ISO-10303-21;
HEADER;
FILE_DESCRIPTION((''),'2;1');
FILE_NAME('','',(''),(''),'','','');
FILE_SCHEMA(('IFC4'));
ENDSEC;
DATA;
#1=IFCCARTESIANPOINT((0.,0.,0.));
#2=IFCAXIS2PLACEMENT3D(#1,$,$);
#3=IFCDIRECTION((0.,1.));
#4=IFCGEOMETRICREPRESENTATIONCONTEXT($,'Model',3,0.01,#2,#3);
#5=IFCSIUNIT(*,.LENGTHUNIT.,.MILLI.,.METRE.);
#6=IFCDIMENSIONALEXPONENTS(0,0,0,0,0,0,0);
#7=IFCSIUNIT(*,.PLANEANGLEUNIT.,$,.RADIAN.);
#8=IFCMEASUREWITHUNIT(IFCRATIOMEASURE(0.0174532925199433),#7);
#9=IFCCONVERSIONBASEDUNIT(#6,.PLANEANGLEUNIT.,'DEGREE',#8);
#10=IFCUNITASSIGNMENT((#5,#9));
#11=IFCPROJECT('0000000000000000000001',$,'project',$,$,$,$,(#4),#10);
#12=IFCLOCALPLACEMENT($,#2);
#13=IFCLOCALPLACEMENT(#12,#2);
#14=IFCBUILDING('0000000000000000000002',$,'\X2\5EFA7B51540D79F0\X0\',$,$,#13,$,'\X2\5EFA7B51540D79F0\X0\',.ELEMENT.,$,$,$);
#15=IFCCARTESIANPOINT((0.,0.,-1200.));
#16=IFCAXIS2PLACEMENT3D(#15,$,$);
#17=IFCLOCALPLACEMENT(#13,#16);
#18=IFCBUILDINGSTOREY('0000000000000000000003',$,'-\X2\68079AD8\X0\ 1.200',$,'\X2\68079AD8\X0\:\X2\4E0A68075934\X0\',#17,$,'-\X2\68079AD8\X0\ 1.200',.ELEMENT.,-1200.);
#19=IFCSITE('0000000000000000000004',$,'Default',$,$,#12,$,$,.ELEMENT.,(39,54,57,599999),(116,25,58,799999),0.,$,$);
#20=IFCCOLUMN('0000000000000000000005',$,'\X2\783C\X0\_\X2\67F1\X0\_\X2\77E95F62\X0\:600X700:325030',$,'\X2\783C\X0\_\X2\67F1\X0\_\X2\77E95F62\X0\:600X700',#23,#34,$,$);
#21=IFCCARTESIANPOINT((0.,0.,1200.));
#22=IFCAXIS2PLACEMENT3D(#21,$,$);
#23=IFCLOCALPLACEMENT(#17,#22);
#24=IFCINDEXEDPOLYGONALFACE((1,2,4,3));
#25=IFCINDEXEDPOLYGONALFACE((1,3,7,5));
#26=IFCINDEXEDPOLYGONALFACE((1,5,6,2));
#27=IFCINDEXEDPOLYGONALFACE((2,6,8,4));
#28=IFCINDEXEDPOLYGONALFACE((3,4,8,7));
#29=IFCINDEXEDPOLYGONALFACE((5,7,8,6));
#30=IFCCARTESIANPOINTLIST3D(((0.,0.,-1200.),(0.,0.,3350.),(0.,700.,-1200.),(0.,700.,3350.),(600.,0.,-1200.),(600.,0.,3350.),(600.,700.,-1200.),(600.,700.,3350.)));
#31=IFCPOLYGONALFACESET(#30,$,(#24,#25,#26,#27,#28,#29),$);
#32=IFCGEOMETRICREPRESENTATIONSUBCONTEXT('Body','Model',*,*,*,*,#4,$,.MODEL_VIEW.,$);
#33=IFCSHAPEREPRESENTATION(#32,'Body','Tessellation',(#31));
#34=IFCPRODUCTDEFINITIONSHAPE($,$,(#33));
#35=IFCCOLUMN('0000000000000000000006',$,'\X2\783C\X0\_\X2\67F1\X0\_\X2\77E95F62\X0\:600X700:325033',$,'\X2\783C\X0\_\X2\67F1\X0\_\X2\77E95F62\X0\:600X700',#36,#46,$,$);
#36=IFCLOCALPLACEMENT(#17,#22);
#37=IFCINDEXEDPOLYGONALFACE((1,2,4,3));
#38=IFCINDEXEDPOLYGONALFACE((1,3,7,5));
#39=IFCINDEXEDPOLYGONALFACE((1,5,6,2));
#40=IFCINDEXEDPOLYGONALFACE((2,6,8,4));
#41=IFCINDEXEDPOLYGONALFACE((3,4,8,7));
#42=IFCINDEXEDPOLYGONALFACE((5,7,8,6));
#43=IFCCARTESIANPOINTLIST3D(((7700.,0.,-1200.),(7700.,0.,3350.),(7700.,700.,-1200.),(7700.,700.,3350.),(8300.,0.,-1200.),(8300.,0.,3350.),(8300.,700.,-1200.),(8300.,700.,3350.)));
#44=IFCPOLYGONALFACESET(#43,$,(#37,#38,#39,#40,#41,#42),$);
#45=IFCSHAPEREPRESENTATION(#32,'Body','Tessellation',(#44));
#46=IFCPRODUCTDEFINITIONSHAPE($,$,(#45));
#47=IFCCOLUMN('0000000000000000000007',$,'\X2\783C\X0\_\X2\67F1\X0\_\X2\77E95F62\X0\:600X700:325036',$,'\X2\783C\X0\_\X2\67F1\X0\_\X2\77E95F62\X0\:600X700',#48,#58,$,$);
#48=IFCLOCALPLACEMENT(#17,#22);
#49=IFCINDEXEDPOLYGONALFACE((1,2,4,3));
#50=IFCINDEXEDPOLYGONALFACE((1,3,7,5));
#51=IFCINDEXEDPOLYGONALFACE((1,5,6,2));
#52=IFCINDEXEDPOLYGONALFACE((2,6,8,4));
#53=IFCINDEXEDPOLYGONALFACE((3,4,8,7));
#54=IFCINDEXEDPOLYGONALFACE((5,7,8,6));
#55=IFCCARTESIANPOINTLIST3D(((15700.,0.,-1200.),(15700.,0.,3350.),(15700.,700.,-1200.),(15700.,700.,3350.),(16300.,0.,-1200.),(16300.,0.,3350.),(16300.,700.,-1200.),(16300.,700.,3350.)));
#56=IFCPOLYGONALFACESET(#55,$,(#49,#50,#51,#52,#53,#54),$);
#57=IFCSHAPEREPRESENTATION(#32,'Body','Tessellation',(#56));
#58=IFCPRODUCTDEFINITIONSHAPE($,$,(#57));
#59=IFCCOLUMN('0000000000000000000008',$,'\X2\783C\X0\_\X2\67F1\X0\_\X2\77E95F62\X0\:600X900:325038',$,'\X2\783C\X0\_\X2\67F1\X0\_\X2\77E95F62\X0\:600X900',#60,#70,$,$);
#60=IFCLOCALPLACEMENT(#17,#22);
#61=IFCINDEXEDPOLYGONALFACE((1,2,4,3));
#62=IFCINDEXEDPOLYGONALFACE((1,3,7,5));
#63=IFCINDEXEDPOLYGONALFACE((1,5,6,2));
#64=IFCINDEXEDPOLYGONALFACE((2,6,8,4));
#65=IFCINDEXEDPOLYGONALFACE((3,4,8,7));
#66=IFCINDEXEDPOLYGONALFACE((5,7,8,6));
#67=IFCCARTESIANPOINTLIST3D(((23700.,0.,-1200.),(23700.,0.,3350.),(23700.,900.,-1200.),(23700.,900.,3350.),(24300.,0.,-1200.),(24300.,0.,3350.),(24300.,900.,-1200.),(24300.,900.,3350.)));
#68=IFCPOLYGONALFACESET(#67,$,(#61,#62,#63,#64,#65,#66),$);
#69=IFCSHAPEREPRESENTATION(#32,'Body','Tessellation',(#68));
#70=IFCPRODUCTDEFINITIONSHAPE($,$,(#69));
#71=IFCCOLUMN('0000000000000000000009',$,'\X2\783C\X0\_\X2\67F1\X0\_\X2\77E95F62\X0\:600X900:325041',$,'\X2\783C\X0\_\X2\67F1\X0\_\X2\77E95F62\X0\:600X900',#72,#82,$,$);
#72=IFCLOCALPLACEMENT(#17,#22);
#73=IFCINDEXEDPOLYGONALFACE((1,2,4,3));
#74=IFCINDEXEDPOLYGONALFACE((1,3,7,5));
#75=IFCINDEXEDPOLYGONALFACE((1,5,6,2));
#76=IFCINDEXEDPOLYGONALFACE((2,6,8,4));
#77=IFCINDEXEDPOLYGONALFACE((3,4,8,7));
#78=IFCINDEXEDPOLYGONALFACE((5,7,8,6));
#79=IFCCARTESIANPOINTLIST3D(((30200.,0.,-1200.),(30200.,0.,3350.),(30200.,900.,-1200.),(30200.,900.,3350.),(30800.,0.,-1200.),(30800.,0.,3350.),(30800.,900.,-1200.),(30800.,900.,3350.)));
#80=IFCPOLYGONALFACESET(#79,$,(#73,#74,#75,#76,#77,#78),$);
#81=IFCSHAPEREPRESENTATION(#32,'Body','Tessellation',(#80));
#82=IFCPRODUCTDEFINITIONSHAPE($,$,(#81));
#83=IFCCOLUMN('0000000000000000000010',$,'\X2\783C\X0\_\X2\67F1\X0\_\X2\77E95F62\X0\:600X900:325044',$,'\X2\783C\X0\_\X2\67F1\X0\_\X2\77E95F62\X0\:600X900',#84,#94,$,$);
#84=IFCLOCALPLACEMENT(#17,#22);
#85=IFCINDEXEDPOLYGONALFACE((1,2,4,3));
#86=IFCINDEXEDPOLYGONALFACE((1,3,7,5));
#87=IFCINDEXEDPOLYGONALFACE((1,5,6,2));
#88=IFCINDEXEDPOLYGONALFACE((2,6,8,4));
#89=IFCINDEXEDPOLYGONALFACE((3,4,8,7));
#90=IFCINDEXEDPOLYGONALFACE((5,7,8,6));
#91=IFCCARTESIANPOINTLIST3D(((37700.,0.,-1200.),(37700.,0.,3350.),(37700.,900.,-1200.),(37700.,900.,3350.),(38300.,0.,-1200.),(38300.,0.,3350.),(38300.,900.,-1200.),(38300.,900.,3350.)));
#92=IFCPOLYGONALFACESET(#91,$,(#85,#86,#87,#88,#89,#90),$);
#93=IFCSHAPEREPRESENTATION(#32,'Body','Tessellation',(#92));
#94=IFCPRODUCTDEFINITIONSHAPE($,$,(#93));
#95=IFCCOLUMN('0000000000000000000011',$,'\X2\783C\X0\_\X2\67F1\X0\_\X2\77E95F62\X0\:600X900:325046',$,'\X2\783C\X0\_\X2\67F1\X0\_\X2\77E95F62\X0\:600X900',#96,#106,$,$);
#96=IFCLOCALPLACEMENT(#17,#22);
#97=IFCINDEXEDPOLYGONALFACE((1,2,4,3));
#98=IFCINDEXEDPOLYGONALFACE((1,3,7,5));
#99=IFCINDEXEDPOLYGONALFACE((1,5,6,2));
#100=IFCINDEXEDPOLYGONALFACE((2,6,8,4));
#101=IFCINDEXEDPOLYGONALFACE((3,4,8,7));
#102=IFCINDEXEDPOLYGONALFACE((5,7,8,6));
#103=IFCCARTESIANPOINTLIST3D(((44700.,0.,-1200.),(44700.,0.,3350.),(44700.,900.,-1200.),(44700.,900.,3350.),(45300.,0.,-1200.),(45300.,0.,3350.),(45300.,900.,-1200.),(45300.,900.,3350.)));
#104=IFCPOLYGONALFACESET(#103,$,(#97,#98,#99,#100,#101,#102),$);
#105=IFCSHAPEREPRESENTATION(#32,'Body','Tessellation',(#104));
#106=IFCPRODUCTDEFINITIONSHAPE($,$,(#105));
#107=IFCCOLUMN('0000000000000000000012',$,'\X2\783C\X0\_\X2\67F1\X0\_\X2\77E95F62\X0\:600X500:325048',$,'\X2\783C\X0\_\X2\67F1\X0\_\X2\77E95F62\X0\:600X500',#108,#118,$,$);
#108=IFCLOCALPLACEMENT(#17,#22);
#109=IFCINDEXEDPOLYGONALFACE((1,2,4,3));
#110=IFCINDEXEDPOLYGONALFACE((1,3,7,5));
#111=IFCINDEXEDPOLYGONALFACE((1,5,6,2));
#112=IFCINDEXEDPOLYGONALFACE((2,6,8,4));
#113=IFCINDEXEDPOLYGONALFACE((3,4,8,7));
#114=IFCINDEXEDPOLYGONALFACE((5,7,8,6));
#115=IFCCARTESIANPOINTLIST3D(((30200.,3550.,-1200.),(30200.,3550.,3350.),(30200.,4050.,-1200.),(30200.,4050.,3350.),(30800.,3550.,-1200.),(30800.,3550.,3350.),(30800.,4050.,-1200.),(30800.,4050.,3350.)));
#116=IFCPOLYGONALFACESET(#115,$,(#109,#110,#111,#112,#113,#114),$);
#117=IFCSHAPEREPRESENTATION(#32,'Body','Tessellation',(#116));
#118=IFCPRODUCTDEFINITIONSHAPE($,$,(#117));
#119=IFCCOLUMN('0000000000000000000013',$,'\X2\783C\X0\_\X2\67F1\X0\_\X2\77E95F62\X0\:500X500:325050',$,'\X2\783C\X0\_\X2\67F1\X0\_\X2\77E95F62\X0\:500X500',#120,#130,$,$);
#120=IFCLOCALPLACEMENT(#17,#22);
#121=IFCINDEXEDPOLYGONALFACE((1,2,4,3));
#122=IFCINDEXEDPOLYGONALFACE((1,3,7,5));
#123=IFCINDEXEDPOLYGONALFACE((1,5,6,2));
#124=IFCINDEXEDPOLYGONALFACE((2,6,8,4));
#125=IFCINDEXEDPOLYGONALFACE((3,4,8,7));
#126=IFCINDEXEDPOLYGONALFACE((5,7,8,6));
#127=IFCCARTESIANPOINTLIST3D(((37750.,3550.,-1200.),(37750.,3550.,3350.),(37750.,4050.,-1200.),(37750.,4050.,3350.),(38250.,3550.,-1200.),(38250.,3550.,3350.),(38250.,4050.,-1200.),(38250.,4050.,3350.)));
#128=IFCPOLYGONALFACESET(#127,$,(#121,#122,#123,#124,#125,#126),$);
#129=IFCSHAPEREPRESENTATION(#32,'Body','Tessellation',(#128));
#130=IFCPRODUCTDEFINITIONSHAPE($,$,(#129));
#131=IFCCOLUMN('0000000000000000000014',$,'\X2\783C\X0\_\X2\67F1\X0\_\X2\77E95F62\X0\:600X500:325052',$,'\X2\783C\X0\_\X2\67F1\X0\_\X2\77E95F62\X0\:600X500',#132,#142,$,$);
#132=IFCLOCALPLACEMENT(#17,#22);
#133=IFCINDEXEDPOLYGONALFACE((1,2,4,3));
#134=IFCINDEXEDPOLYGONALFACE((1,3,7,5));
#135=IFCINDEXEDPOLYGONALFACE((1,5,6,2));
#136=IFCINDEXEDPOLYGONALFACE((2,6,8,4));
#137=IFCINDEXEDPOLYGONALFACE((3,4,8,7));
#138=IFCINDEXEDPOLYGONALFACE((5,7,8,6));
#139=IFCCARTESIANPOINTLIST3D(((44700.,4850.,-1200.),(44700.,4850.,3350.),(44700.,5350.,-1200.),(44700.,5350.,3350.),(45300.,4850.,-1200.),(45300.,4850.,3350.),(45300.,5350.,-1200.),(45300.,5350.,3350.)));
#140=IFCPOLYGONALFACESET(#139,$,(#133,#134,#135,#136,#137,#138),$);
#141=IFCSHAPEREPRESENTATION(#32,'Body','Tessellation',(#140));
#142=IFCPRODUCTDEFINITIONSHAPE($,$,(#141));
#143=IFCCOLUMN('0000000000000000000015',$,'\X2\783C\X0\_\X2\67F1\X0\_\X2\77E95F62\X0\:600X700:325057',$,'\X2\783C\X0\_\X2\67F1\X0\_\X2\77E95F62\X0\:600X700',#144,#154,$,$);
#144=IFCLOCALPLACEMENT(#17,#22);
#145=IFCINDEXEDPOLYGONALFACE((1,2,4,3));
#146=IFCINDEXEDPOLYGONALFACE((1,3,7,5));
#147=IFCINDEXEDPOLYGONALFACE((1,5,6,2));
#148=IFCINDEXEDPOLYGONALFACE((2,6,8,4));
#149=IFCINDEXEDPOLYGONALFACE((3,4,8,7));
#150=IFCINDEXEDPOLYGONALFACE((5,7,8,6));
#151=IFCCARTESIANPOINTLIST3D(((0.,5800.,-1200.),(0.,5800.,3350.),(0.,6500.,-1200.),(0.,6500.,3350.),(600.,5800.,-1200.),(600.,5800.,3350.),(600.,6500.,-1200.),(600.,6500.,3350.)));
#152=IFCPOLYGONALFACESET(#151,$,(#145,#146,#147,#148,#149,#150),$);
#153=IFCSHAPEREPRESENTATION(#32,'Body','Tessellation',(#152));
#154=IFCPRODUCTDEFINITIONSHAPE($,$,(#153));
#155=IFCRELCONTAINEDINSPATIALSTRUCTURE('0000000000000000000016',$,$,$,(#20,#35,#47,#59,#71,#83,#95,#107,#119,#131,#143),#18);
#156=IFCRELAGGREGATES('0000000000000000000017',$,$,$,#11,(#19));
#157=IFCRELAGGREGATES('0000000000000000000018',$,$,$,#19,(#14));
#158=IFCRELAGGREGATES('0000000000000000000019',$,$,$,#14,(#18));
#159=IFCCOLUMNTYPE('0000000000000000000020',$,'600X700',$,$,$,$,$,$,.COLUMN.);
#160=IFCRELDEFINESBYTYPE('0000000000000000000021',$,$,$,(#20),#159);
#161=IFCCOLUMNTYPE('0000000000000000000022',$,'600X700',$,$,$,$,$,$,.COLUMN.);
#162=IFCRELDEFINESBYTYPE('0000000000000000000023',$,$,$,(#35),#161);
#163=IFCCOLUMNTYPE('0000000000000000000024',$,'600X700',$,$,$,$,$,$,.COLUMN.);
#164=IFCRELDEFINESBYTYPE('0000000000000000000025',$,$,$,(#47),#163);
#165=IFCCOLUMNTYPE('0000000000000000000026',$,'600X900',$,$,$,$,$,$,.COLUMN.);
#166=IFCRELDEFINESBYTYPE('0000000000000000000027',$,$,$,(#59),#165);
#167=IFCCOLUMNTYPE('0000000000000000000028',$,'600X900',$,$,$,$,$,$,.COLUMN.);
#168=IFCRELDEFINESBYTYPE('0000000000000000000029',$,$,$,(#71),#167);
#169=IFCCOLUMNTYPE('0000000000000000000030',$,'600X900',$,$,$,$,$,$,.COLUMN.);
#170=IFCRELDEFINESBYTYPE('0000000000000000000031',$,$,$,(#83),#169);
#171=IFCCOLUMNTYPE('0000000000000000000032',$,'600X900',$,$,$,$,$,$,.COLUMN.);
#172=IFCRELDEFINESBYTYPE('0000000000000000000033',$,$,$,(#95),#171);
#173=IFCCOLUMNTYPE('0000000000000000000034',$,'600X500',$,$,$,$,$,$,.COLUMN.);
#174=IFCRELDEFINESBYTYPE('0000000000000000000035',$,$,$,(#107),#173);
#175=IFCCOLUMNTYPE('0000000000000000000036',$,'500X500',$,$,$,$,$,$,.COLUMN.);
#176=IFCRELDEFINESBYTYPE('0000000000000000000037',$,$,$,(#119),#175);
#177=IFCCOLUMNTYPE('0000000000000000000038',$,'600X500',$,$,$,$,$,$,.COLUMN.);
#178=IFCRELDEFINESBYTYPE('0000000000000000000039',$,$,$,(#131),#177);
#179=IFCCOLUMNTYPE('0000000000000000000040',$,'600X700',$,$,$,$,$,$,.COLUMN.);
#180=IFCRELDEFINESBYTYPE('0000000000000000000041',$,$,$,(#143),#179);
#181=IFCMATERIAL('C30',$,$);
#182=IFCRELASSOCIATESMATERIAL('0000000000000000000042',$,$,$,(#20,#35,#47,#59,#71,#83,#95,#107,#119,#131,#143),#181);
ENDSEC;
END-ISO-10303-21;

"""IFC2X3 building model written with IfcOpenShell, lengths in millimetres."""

from ifc_helpers import new_model, entity, si_unit, converted_unit, direction, frame, frame_2d, origin, origin_2d_with_axis, place, context, subcontext, project, spatial, rectangle, extrude, source, transform, mapped, material, type_object, type_shapes, element, save


model = new_model("IFC2X3")

# Units and contexts
model_context = context("Model", 3, precision=0.01, world=origin(), true_north=direction((0.0, 1.0)))
body_context = subcontext(model_context, "Body", "Model", "MODEL_VIEW")
ifc_project = project(units=[si_unit("LENGTHUNIT", "METRE", prefix="MILLI"), converted_unit("PLANEANGLEUNIT", "DEGREE", entity("IfcRatioMeasure", 0.0174532925199433), si_unit("PLANEANGLEUNIT", "RADIAN"), dimensions=[0, 0, 0, 0, 0, 0, 0])], contexts=[model_context])

# Site, building, storey
site_placement = place(None, origin())
site = spatial("IfcSite", under=ifc_project, at=site_placement, Name="Default", CompositionType="ELEMENT", RefLatitude=(39, 54, 57, 599999), RefLongitude=(116, 25, 58, 799999), RefElevation=0.0)
building_placement = place(site_placement, origin())
building = spatial("IfcBuilding", under=site, at=building_placement, Name="建筑名称", LongName="建筑名称", CompositionType="ELEMENT")
storey_placement = place(building_placement, frame((0.0, 0.0, -1200.0)))
storey = spatial("IfcBuildingStorey", under=building, at=storey_placement, Name="-标高 1.200", ObjectType="标高:上标头", LongName="-标高 1.200", CompositionType="ELEMENT", Elevation=-1200.0)

# Columns
ifc_material = material(Name="C30")
column_type_1 = type_object("IfcColumnType", Name="600X700", PredefinedType="COLUMN")
shared_shape_1 = source(origin(), body_context, "Body", "SweptSolid", [
    extrude(rectangle(XDim=700.0, YDim=600.0, at=origin_2d_with_axis()), frame((300.0, 350.0, -1200.0), z_axis=(0.0, 0.0, 1.0), x_axis=(0.0, -1.0, 0.0)), (0.0, 0.0, 1.0), 4550.0),
])
type_shapes(column_type_1, [shared_shape_1])
column_1_placement = place(storey_placement, frame((0.0, 0.0, 1200.0)))
element("IfcColumn", 1, at=column_1_placement, inside=storey, type_object=column_type_1, material=ifc_material, Name="砼_柱_矩形:600X700:325030", ObjectType="砼_柱_矩形:600X700", context=body_context, shape_type="MappedRepresentation", body=[
    mapped(shared_shape_1, transform((0.0, 0.0, 0.0), scale=1.0)),
])
column_type_2 = type_object("IfcColumnType", Name="600X700", PredefinedType="COLUMN")
shared_shape_2 = source(origin(), body_context, "Body", "SweptSolid", [
    extrude(rectangle(XDim=700.0, YDim=600.0, at=origin_2d_with_axis()), frame((8000.0, 350.0, -1200.0), z_axis=(0.0, 0.0, 1.0), x_axis=(0.0, -1.0, 0.0)), (0.0, 0.0, 1.0), 4550.0),
])
type_shapes(column_type_2, [shared_shape_2])
column_2_placement = place(storey_placement, frame((0.0, 0.0, 1200.0)))
element("IfcColumn", 2, at=column_2_placement, inside=storey, type_object=column_type_2, material=ifc_material, Name="砼_柱_矩形:600X700:325033", ObjectType="砼_柱_矩形:600X700", context=body_context, shape_type="MappedRepresentation", body=[
    mapped(shared_shape_2, transform((0.0, 0.0, 0.0), scale=1.0)),
])
column_type_3 = type_object("IfcColumnType", Name="600X700", PredefinedType="COLUMN")
shared_shape_3 = source(origin(), body_context, "Body", "SweptSolid", [
    extrude(rectangle(XDim=700.0, YDim=600.0, at=frame_2d((0.0, 0.0), x_axis=(1.0, 0.0))), frame((16000.0, 350.0, -1200.0), z_axis=(0.0, 0.0, 1.0), x_axis=(0.0, -1.0, 0.0)), (0.0, 0.0, 1.0), 4550.0),
])
type_shapes(column_type_3, [shared_shape_3])
column_3_placement = place(storey_placement, frame((0.0, 0.0, 1200.0)))
element("IfcColumn", 3, at=column_3_placement, inside=storey, type_object=column_type_3, material=ifc_material, Name="砼_柱_矩形:600X700:325036", ObjectType="砼_柱_矩形:600X700", context=body_context, shape_type="MappedRepresentation", body=[
    mapped(shared_shape_3, transform((0.0, 0.0, 0.0), scale=1.0)),
])
column_type_4 = type_object("IfcColumnType", Name="600X900", PredefinedType="COLUMN")
shared_shape_4 = source(origin(), body_context, "Body", "SweptSolid", [
    extrude(rectangle(XDim=900.0, YDim=600.0, at=origin_2d_with_axis()), frame((24000.0, 450.0, -1200.0), z_axis=(0.0, 0.0, 1.0), x_axis=(0.0, -1.0, 0.0)), (0.0, 0.0, 1.0), 4550.0),
])
type_shapes(column_type_4, [shared_shape_4])
column_4_placement = place(storey_placement, frame((0.0, 0.0, 1200.0)))
element("IfcColumn", 4, at=column_4_placement, inside=storey, type_object=column_type_4, material=ifc_material, Name="砼_柱_矩形:600X900:325038", ObjectType="砼_柱_矩形:600X900", context=body_context, shape_type="MappedRepresentation", body=[
    mapped(shared_shape_4, transform((0.0, 0.0, 0.0), scale=1.0)),
])
column_type_5 = type_object("IfcColumnType", Name="600X900", PredefinedType="COLUMN")
shared_shape_5 = source(origin(), body_context, "Body", "SweptSolid", [
    extrude(rectangle(XDim=900.0, YDim=600.0, at=origin_2d_with_axis()), frame((30500.0, 450.0, -1200.0), z_axis=(0.0, 0.0, 1.0), x_axis=(0.0, -1.0, 0.0)), (0.0, 0.0, 1.0), 4550.0),
])
type_shapes(column_type_5, [shared_shape_5])
column_5_placement = place(storey_placement, frame((0.0, 0.0, 1200.0)))
element("IfcColumn", 5, at=column_5_placement, inside=storey, type_object=column_type_5, material=ifc_material, Name="砼_柱_矩形:600X900:325041", ObjectType="砼_柱_矩形:600X900", context=body_context, shape_type="MappedRepresentation", body=[
    mapped(shared_shape_5, transform((0.0, 0.0, 0.0), scale=1.0)),
])
column_type_6 = type_object("IfcColumnType", Name="600X900", PredefinedType="COLUMN")
shared_shape_6 = source(origin(), body_context, "Body", "SweptSolid", [
    extrude(rectangle(XDim=900.0, YDim=600.0, at=origin_2d_with_axis()), frame((38000.0, 450.0, -1200.0), z_axis=(0.0, 0.0, 1.0), x_axis=(0.0, -1.0, 0.0)), (0.0, 0.0, 1.0), 4550.0),
])
type_shapes(column_type_6, [shared_shape_6])
column_6_placement = place(storey_placement, frame((0.0, 0.0, 1200.0)))
element("IfcColumn", 6, at=column_6_placement, inside=storey, type_object=column_type_6, material=ifc_material, Name="砼_柱_矩形:600X900:325044", ObjectType="砼_柱_矩形:600X900", context=body_context, shape_type="MappedRepresentation", body=[
    mapped(shared_shape_6, transform((0.0, 0.0, 0.0), scale=1.0)),
])
column_type_7 = type_object("IfcColumnType", Name="600X900", PredefinedType="COLUMN")
shared_shape_7 = source(origin(), body_context, "Body", "SweptSolid", [
    extrude(rectangle(XDim=900.0, YDim=600.0, at=origin_2d_with_axis()), frame((45000.0, 450.0, -1200.0), z_axis=(0.0, 0.0, 1.0), x_axis=(0.0, -1.0, 0.0)), (0.0, 0.0, 1.0), 4550.0),
])
type_shapes(column_type_7, [shared_shape_7])
column_7_placement = place(storey_placement, frame((0.0, 0.0, 1200.0)))
element("IfcColumn", 7, at=column_7_placement, inside=storey, type_object=column_type_7, material=ifc_material, Name="砼_柱_矩形:600X900:325046", ObjectType="砼_柱_矩形:600X900", context=body_context, shape_type="MappedRepresentation", body=[
    mapped(shared_shape_7, transform((0.0, 0.0, 0.0), scale=1.0)),
])
column_type_8 = type_object("IfcColumnType", Name="600X500", PredefinedType="COLUMN")
shared_shape_8 = source(origin(), body_context, "Body", "SweptSolid", [
    extrude(rectangle(XDim=500.0, YDim=600.0, at=origin_2d_with_axis()), frame((30500.0, 3800.0, -1200.0), z_axis=(0.0, 0.0, 1.0), x_axis=(0.0, -1.0, 0.0)), (0.0, 0.0, 1.0), 4550.0),
])
type_shapes(column_type_8, [shared_shape_8])
column_8_placement = place(storey_placement, frame((0.0, 0.0, 1200.0)))
element("IfcColumn", 8, at=column_8_placement, inside=storey, type_object=column_type_8, material=ifc_material, Name="砼_柱_矩形:600X500:325048", ObjectType="砼_柱_矩形:600X500", context=body_context, shape_type="MappedRepresentation", body=[
    mapped(shared_shape_8, transform((0.0, 0.0, 0.0), scale=1.0)),
])
column_type_9 = type_object("IfcColumnType", Name="500X500", PredefinedType="COLUMN")
shared_shape_9 = source(origin(), body_context, "Body", "SweptSolid", [
    extrude(rectangle(XDim=500.0, YDim=500.0, at=origin_2d_with_axis()), frame((38000.0, 3800.0, -1200.0), z_axis=(0.0, 0.0, 1.0), x_axis=(0.0, -1.0, 0.0)), (0.0, 0.0, 1.0), 4550.0),
])
type_shapes(column_type_9, [shared_shape_9])
column_9_placement = place(storey_placement, frame((0.0, 0.0, 1200.0)))
element("IfcColumn", 9, at=column_9_placement, inside=storey, type_object=column_type_9, material=ifc_material, Name="砼_柱_矩形:500X500:325050", ObjectType="砼_柱_矩形:500X500", context=body_context, shape_type="MappedRepresentation", body=[
    mapped(shared_shape_9, transform((0.0, 0.0, 0.0), scale=1.0)),
])
column_type_10 = type_object("IfcColumnType", Name="600X500", PredefinedType="COLUMN")
shared_shape_10 = source(origin(), body_context, "Body", "SweptSolid", [
    extrude(rectangle(XDim=500.0, YDim=600.0, at=frame_2d((0.0, 0.0), x_axis=(1.0, 0.0))), frame((45000.0, 5100.0, -1200.0), z_axis=(0.0, 0.0, 1.0), x_axis=(0.0, -1.0, 0.0)), (0.0, 0.0, 1.0), 4550.0),
])
type_shapes(column_type_10, [shared_shape_10])
column_10_placement = place(storey_placement, frame((0.0, 0.0, 1200.0)))
element("IfcColumn", 10, at=column_10_placement, inside=storey, type_object=column_type_10, material=ifc_material, Name="砼_柱_矩形:600X500:325052", ObjectType="砼_柱_矩形:600X500", context=body_context, shape_type="MappedRepresentation", body=[
    mapped(shared_shape_10, transform((0.0, 0.0, 0.0), scale=1.0)),
])
column_type_11 = type_object("IfcColumnType", Name="600X700", PredefinedType="COLUMN")
shared_shape_11 = source(origin(), body_context, "Body", "SweptSolid", [
    extrude(rectangle(XDim=700.0, YDim=600.0, at=origin_2d_with_axis()), frame((300.0, 6150.0, -1200.0), z_axis=(0.0, 0.0, 1.0), x_axis=(0.0, -1.0, 0.0)), (0.0, 0.0, 1.0), 4550.0),
])
type_shapes(column_type_11, [shared_shape_11])
column_11_placement = place(storey_placement, frame((0.0, 0.0, 1200.0)))
element("IfcColumn", 11, at=column_11_placement, inside=storey, type_object=column_type_11, material=ifc_material, Name="砼_柱_矩形:600X700:325057", ObjectType="砼_柱_矩形:600X700", context=body_context, shape_type="MappedRepresentation", body=[
    mapped(shared_shape_11, transform((0.0, 0.0, 0.0), scale=1.0)),
])

save(model, "model.ifc")
